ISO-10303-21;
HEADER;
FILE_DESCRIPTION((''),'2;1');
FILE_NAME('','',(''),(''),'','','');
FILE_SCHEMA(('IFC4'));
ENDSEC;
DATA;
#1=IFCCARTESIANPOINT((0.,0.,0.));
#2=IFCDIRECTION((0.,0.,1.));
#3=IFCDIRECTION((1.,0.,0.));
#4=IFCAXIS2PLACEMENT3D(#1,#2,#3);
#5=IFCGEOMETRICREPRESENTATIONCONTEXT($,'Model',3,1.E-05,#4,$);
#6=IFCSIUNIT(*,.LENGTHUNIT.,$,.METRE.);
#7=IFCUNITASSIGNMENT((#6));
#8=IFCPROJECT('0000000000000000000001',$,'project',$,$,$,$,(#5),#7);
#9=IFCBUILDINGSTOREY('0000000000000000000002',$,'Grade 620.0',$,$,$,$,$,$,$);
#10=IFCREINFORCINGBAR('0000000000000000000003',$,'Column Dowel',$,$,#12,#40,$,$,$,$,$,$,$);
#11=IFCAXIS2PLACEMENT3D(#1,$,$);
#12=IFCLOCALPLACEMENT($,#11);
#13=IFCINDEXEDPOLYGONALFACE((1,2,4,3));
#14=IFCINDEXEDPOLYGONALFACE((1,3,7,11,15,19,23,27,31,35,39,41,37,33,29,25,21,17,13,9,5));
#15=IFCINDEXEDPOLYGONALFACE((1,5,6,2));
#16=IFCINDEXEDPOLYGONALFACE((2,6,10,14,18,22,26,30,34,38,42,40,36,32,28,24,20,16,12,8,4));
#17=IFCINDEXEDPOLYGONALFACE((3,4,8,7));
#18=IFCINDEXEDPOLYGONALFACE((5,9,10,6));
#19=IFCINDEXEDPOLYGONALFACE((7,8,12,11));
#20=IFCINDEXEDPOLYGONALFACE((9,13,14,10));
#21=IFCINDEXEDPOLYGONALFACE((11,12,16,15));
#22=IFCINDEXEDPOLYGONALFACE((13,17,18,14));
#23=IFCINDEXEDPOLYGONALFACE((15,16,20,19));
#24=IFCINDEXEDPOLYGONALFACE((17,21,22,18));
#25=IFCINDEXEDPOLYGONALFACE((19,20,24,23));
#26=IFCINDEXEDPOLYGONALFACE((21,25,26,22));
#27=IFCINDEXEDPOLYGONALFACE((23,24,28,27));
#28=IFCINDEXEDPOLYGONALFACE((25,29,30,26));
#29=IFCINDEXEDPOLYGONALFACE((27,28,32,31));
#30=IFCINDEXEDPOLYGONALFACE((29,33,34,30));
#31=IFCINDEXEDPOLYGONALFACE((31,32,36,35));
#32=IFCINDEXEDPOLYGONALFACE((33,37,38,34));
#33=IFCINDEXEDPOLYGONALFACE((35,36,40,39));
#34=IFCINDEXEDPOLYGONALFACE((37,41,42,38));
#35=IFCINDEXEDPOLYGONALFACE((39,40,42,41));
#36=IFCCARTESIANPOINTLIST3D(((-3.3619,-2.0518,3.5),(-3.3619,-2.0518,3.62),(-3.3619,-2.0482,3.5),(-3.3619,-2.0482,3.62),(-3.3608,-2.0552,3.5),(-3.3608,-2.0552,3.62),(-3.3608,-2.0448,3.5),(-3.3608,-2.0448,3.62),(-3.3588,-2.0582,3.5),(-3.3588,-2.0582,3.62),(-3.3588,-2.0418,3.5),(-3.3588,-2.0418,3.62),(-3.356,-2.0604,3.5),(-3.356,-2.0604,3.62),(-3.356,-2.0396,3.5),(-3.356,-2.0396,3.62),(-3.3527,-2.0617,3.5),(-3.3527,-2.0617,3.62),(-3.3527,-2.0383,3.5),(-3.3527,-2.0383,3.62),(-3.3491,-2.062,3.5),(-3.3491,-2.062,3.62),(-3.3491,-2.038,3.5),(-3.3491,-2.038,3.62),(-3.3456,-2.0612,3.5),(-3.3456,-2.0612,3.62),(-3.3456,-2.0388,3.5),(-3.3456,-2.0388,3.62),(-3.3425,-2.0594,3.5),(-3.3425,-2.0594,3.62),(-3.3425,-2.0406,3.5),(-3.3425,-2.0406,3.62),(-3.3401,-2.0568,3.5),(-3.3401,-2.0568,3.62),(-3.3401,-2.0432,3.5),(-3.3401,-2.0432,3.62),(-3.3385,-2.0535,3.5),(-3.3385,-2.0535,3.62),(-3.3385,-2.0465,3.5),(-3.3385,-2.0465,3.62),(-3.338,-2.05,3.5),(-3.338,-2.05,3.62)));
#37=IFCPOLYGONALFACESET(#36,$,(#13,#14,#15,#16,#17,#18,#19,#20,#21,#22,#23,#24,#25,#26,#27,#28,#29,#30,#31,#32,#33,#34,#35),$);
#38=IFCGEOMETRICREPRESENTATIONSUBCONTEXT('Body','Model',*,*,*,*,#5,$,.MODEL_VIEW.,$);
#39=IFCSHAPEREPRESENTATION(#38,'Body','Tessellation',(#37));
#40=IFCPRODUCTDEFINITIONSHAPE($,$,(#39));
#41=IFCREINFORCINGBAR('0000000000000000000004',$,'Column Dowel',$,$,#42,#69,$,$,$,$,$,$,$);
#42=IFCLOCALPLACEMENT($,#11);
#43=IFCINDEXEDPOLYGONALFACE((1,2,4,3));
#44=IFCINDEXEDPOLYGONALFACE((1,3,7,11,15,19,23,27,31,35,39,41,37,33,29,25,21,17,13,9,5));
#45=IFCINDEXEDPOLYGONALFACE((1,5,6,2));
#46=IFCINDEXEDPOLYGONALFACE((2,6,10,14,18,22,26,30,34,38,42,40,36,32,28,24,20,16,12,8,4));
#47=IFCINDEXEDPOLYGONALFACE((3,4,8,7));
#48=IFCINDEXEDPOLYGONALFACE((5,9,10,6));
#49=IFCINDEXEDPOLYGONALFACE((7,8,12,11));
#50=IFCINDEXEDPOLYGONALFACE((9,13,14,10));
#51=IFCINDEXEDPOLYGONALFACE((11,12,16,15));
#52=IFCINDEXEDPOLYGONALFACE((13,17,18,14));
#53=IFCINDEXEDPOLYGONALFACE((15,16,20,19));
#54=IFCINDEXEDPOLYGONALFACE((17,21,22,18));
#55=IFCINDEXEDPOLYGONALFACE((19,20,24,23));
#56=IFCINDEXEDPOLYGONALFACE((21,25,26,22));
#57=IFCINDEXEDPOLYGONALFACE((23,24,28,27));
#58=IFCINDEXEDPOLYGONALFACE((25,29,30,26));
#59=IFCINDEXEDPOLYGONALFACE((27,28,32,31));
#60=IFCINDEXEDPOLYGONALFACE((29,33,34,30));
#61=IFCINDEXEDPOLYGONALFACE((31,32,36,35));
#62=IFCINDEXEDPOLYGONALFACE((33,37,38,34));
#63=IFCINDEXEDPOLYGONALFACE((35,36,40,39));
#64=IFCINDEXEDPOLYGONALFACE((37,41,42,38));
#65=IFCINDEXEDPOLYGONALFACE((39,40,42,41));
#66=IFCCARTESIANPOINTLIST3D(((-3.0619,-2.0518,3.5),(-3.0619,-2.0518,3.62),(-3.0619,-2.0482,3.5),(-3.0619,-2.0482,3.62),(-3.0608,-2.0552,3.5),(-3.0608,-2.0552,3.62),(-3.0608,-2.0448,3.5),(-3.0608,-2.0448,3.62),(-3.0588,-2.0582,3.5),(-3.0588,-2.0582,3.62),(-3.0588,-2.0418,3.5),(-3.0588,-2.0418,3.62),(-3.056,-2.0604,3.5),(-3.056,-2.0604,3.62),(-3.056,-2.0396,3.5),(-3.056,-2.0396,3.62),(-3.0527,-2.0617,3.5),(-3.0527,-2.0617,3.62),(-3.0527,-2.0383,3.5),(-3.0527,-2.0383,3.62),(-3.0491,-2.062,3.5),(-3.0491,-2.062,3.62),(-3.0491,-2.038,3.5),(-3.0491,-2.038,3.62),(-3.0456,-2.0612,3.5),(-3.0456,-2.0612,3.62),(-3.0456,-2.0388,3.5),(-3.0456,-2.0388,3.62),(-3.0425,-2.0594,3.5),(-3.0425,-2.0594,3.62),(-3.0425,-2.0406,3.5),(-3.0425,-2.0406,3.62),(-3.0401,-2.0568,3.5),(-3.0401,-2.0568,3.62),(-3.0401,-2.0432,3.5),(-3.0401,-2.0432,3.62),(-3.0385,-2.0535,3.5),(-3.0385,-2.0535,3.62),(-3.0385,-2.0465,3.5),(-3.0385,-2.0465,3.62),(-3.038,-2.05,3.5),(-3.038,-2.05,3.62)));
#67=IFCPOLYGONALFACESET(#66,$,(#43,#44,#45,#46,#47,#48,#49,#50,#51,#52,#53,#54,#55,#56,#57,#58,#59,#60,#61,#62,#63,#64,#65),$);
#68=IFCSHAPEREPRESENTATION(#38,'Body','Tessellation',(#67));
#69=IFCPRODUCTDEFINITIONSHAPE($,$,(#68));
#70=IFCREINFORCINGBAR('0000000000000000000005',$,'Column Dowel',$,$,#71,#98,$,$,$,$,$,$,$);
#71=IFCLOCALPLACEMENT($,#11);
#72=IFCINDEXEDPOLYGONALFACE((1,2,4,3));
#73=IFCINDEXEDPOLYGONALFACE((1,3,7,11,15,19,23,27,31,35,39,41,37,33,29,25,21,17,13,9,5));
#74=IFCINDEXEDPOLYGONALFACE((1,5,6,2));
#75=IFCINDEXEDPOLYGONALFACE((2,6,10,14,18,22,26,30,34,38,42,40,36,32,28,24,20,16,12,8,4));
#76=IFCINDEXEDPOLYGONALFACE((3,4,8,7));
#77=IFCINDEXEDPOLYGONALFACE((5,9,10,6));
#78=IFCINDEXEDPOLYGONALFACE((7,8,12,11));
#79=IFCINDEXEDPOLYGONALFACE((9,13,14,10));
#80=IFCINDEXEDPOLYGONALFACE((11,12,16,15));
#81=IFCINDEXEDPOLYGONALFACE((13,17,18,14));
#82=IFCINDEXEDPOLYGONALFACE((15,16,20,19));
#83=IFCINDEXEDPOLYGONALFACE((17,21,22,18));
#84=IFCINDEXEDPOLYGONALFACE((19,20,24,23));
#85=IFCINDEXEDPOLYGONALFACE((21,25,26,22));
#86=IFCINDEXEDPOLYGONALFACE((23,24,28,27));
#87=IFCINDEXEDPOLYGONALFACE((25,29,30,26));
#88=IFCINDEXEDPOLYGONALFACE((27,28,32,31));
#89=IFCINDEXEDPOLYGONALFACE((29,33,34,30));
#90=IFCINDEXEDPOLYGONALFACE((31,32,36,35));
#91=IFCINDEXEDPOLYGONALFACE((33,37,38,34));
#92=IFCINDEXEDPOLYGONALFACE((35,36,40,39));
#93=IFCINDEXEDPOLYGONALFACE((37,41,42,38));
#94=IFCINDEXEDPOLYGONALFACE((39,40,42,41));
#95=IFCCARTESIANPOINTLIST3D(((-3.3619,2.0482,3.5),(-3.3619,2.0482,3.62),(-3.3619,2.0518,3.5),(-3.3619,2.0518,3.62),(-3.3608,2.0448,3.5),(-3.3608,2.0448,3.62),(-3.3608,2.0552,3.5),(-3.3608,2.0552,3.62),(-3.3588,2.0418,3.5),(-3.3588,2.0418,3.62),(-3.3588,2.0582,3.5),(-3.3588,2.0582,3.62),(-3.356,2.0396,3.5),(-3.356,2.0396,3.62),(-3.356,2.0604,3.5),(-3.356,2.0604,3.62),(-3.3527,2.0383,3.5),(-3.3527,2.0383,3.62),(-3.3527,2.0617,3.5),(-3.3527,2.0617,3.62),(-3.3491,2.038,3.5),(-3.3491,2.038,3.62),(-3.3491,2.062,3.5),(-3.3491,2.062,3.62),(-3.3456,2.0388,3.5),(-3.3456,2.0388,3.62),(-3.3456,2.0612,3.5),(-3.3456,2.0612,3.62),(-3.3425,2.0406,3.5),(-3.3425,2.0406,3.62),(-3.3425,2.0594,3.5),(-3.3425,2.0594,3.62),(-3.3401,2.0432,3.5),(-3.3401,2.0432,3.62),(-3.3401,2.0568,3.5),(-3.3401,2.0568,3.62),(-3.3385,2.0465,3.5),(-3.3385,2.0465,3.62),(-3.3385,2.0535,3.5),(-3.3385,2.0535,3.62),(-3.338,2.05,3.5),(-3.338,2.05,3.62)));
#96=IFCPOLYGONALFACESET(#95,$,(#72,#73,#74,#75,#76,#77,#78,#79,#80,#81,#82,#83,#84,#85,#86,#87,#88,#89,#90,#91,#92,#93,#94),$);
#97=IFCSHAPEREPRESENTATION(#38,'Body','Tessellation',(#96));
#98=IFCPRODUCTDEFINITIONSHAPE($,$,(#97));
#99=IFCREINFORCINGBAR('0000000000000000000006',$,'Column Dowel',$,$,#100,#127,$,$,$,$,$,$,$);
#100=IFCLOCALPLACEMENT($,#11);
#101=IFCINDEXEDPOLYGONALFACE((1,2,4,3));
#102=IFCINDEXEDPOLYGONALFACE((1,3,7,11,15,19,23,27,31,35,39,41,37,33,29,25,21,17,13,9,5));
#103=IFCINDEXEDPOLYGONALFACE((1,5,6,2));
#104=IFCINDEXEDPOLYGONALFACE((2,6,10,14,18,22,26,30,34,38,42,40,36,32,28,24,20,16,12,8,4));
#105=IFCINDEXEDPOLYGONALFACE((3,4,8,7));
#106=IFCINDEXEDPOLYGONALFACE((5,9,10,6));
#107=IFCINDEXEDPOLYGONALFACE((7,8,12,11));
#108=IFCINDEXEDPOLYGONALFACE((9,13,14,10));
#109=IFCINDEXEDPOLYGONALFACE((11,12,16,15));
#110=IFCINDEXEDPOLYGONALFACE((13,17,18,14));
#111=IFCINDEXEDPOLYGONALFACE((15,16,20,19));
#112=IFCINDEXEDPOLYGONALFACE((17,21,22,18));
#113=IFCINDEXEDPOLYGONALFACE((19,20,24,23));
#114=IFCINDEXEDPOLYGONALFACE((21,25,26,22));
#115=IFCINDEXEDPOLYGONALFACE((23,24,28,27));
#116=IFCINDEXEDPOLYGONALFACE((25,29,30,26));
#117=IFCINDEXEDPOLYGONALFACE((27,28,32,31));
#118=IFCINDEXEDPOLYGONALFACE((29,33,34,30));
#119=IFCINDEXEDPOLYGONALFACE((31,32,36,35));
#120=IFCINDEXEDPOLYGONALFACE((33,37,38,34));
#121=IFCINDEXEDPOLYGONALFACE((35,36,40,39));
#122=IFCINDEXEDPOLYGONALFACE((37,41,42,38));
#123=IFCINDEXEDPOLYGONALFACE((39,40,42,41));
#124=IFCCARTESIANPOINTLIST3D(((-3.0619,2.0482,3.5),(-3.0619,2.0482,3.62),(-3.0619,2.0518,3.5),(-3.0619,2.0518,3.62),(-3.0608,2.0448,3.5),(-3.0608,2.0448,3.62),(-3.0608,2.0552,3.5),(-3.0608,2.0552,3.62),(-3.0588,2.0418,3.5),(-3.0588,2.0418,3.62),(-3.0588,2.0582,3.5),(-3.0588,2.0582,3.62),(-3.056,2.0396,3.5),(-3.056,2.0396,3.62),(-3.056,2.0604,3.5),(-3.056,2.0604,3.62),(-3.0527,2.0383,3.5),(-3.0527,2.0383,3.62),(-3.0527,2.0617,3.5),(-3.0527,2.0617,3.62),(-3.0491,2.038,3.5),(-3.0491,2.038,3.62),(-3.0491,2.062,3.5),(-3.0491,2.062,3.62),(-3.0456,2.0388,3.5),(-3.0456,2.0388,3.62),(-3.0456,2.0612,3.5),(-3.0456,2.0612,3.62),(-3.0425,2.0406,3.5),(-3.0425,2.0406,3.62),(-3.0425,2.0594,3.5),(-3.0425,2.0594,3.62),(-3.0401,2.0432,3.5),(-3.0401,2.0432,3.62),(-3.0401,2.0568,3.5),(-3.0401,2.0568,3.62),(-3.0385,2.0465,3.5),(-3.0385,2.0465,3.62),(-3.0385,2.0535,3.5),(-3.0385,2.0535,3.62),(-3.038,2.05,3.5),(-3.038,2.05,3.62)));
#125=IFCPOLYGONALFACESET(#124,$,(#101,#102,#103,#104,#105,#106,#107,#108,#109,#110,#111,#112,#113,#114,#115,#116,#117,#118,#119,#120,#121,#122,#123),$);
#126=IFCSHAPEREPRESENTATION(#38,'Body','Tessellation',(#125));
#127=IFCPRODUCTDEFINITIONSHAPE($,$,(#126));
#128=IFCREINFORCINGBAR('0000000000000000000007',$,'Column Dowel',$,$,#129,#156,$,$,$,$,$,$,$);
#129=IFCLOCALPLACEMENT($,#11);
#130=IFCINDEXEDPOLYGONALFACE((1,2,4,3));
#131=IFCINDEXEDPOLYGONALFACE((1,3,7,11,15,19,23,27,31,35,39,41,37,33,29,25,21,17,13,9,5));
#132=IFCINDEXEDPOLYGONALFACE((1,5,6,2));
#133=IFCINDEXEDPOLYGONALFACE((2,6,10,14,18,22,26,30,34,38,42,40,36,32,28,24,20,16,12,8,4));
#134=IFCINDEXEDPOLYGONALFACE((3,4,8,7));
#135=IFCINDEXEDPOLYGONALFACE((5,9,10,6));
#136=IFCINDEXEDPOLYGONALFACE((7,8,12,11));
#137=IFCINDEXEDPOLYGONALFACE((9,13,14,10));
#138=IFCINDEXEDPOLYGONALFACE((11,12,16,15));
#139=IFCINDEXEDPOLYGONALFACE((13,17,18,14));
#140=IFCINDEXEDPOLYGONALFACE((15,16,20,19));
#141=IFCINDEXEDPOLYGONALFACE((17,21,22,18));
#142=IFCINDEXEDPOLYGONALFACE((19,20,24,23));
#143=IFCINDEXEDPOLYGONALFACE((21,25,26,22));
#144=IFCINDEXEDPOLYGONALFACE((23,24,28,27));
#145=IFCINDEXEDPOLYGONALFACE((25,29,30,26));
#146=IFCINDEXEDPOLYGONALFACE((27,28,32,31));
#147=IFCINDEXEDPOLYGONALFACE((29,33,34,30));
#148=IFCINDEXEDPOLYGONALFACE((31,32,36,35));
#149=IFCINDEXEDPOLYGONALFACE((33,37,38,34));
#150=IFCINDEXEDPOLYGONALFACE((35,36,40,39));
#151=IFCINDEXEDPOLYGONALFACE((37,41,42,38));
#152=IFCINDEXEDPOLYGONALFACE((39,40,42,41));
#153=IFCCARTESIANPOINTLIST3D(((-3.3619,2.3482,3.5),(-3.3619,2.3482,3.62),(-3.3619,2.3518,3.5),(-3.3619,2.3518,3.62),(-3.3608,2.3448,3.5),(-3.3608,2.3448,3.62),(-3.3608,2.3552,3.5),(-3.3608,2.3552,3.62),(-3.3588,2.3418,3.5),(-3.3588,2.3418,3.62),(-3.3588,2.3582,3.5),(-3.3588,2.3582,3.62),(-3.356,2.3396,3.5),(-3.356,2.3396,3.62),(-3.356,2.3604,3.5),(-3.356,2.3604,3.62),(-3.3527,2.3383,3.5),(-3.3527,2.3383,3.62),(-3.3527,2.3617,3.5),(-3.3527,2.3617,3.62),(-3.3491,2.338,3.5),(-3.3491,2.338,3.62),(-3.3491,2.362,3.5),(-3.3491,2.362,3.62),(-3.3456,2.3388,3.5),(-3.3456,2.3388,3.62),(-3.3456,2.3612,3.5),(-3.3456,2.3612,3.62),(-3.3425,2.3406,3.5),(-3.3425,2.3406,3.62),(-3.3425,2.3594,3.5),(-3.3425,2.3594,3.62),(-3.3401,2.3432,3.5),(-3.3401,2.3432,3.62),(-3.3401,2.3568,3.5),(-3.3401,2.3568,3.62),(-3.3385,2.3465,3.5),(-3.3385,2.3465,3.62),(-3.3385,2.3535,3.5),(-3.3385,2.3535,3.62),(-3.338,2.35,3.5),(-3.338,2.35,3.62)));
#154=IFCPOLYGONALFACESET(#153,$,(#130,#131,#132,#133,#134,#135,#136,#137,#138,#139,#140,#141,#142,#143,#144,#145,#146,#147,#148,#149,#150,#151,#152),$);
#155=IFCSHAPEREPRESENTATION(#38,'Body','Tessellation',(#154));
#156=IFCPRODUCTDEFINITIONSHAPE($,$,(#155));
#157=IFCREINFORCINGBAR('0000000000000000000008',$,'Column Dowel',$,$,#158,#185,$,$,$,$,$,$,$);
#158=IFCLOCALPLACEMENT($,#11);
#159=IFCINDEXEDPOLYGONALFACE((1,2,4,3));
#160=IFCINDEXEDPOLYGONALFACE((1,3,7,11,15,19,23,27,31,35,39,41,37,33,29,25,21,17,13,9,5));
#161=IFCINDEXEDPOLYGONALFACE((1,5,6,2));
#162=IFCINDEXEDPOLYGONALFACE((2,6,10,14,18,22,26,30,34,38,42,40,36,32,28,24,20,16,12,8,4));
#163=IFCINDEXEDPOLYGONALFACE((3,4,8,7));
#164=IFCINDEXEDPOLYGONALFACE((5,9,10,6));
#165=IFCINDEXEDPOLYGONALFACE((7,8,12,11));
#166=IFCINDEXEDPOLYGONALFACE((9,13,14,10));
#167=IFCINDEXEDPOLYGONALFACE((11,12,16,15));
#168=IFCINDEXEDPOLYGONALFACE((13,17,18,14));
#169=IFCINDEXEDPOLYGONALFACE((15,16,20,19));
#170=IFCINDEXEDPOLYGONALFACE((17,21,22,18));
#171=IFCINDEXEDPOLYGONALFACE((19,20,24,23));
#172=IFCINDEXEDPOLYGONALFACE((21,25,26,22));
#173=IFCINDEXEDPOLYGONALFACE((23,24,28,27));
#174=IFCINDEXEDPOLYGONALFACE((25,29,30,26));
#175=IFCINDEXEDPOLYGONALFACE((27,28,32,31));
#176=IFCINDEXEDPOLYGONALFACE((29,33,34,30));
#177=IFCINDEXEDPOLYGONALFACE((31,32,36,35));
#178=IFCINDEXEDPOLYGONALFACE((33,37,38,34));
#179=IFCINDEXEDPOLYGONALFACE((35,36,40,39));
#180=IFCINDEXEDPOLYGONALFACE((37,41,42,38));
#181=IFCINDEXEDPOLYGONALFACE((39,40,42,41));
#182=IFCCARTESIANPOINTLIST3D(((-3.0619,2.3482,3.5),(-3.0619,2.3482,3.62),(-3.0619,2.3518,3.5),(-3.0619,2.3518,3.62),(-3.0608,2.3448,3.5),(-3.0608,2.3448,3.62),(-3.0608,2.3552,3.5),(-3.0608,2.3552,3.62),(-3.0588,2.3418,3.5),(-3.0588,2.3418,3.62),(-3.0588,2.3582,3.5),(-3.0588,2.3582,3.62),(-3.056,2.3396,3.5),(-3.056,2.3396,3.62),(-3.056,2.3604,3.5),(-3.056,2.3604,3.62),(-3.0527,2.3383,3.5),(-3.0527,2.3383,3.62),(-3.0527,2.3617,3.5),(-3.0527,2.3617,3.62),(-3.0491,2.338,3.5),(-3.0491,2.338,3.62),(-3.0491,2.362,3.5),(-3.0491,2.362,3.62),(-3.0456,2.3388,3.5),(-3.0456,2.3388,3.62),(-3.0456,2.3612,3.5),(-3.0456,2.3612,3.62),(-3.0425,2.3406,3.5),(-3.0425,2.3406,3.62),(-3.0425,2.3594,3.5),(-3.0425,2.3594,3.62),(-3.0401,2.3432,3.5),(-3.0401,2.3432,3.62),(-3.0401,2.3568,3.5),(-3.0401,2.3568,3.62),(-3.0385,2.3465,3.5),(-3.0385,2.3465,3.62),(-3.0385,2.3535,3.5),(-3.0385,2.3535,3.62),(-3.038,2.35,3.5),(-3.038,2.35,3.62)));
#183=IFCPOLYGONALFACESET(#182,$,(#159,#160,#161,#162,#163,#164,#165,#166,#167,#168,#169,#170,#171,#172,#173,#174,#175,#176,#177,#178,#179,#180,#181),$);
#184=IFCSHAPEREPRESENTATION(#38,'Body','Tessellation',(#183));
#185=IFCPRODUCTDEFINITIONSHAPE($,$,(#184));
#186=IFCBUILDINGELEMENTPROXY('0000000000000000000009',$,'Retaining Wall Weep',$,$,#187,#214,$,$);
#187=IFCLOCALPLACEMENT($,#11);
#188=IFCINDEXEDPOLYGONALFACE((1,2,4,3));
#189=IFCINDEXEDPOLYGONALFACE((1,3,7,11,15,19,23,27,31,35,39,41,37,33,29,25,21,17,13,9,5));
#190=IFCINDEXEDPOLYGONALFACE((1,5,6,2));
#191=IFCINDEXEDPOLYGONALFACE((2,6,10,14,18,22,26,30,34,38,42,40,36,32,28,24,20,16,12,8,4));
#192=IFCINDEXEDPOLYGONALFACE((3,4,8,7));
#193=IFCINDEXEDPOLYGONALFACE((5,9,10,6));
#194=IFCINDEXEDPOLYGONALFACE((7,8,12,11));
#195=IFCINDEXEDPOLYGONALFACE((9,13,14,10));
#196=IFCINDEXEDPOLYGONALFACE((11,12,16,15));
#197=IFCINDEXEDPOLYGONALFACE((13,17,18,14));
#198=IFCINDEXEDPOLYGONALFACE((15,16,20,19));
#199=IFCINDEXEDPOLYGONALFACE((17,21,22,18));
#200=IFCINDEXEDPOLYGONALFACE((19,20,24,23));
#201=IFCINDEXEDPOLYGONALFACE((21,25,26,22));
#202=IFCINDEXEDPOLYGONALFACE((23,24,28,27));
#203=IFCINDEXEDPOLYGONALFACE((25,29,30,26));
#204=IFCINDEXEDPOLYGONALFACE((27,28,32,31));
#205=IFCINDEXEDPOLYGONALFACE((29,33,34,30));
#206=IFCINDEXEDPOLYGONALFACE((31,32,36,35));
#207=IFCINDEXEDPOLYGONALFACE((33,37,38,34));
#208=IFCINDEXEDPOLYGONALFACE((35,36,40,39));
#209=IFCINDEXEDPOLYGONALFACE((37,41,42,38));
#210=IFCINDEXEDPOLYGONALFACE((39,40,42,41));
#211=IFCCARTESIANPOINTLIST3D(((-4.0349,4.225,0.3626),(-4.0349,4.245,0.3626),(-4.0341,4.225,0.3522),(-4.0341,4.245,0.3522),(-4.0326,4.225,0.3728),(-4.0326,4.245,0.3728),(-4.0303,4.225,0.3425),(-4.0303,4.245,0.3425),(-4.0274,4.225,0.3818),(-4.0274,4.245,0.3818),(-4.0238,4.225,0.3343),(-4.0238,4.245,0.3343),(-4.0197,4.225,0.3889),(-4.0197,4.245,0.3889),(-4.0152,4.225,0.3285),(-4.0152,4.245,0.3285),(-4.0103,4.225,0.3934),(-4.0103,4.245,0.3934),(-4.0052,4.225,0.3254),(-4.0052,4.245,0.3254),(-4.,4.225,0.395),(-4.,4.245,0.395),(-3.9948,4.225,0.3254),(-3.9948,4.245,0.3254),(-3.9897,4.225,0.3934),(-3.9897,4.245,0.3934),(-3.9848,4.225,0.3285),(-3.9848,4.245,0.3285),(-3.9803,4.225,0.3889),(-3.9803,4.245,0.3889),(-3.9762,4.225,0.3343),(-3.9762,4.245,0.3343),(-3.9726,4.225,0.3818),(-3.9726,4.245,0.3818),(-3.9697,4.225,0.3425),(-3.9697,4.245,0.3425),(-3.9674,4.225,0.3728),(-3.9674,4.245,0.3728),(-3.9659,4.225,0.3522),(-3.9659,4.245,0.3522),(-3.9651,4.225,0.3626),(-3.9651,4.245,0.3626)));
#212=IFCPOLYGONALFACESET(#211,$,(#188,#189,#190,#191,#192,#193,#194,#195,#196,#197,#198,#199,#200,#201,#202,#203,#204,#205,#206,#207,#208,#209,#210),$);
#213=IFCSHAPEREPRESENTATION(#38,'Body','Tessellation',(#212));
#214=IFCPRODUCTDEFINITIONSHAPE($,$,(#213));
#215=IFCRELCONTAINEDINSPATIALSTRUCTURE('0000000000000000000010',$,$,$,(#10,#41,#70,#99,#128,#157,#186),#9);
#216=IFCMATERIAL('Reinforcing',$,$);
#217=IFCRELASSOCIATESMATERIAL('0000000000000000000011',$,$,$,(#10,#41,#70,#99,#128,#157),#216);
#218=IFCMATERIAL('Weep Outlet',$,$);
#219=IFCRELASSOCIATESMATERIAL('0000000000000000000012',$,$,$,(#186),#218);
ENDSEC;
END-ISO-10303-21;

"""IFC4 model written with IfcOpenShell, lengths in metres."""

from ifc_helpers import new_model, si_unit, frame, origin_with_axes, place, context, subcontext, project, spatial, circle, extrude, material, element, save


model = new_model("IFC4")

# Units and contexts
model_context = context("Model", 3, precision=1e-05, world=origin_with_axes())
body_context = subcontext(model_context, "Body", "Model", "MODEL_VIEW")
ifc_project = project(units=[si_unit("LENGTHUNIT", "METRE")], contexts=[model_context])

# Storey
storey = spatial("IfcBuildingStorey", Name="Grade 620.0")

# Reinforcing bars
ifc_material_1 = material(Name="Reinforcing")
for number, where, z_axis, x_axis, name in (
    (1, (-3.35, -2.05, 3.5), (0.0, 0.0, 1.0), (1.0, 0.0, 0.0), "Column Dowel"),
    (2, (-3.05, -2.05, 3.5), (0.0, 0.0, 1.0), (1.0, 0.0, 0.0), "Column Dowel"),
    (3, (-3.35, 2.05, 3.5), (0.0, 0.0, 1.0), (1.0, 0.0, 0.0), "Column Dowel"),
    (4, (-3.05, 2.05, 3.5), (0.0, 0.0, 1.0), (1.0, 0.0, 0.0), "Column Dowel"),
    (5, (-3.35, 2.35, 3.5), (0.0, 0.0, 1.0), (1.0, 0.0, 0.0), "Column Dowel"),
    (6, (-3.05, 2.35, 3.5), (0.0, 0.0, 1.0), (1.0, 0.0, 0.0), "Column Dowel"),
):
    element("IfcReinforcingBar", number, at=place(None, frame(where, z_axis=z_axis, x_axis=x_axis)), inside=storey, material=ifc_material_1, Name=name, context=body_context, shape_type="SweptSolid", body=[
        extrude(circle(Radius=0.012), origin_with_axes(), (0.0, 0.0, 1.0), 0.12),
    ])

# Building element proxy
ifc_material_2 = material(Name="Weep Outlet")
for number, where, z_axis, x_axis, name in (
    (7, (-4.0, 4.225, 0.36), (0.0, 1.0, 0.0), (0.0, 0.0, 1.0), "Retaining Wall Weep"),
):
    element("IfcBuildingElementProxy", number, at=place(None, frame(where, z_axis=z_axis, x_axis=x_axis)), inside=storey, material=ifc_material_2, Name=name, context=body_context, shape_type="SweptSolid", body=[
        extrude(circle(Radius=0.035), origin_with_axes(), (0.0, 0.0, 1.0), 0.02),
    ])

save(model, "model.ifc")
